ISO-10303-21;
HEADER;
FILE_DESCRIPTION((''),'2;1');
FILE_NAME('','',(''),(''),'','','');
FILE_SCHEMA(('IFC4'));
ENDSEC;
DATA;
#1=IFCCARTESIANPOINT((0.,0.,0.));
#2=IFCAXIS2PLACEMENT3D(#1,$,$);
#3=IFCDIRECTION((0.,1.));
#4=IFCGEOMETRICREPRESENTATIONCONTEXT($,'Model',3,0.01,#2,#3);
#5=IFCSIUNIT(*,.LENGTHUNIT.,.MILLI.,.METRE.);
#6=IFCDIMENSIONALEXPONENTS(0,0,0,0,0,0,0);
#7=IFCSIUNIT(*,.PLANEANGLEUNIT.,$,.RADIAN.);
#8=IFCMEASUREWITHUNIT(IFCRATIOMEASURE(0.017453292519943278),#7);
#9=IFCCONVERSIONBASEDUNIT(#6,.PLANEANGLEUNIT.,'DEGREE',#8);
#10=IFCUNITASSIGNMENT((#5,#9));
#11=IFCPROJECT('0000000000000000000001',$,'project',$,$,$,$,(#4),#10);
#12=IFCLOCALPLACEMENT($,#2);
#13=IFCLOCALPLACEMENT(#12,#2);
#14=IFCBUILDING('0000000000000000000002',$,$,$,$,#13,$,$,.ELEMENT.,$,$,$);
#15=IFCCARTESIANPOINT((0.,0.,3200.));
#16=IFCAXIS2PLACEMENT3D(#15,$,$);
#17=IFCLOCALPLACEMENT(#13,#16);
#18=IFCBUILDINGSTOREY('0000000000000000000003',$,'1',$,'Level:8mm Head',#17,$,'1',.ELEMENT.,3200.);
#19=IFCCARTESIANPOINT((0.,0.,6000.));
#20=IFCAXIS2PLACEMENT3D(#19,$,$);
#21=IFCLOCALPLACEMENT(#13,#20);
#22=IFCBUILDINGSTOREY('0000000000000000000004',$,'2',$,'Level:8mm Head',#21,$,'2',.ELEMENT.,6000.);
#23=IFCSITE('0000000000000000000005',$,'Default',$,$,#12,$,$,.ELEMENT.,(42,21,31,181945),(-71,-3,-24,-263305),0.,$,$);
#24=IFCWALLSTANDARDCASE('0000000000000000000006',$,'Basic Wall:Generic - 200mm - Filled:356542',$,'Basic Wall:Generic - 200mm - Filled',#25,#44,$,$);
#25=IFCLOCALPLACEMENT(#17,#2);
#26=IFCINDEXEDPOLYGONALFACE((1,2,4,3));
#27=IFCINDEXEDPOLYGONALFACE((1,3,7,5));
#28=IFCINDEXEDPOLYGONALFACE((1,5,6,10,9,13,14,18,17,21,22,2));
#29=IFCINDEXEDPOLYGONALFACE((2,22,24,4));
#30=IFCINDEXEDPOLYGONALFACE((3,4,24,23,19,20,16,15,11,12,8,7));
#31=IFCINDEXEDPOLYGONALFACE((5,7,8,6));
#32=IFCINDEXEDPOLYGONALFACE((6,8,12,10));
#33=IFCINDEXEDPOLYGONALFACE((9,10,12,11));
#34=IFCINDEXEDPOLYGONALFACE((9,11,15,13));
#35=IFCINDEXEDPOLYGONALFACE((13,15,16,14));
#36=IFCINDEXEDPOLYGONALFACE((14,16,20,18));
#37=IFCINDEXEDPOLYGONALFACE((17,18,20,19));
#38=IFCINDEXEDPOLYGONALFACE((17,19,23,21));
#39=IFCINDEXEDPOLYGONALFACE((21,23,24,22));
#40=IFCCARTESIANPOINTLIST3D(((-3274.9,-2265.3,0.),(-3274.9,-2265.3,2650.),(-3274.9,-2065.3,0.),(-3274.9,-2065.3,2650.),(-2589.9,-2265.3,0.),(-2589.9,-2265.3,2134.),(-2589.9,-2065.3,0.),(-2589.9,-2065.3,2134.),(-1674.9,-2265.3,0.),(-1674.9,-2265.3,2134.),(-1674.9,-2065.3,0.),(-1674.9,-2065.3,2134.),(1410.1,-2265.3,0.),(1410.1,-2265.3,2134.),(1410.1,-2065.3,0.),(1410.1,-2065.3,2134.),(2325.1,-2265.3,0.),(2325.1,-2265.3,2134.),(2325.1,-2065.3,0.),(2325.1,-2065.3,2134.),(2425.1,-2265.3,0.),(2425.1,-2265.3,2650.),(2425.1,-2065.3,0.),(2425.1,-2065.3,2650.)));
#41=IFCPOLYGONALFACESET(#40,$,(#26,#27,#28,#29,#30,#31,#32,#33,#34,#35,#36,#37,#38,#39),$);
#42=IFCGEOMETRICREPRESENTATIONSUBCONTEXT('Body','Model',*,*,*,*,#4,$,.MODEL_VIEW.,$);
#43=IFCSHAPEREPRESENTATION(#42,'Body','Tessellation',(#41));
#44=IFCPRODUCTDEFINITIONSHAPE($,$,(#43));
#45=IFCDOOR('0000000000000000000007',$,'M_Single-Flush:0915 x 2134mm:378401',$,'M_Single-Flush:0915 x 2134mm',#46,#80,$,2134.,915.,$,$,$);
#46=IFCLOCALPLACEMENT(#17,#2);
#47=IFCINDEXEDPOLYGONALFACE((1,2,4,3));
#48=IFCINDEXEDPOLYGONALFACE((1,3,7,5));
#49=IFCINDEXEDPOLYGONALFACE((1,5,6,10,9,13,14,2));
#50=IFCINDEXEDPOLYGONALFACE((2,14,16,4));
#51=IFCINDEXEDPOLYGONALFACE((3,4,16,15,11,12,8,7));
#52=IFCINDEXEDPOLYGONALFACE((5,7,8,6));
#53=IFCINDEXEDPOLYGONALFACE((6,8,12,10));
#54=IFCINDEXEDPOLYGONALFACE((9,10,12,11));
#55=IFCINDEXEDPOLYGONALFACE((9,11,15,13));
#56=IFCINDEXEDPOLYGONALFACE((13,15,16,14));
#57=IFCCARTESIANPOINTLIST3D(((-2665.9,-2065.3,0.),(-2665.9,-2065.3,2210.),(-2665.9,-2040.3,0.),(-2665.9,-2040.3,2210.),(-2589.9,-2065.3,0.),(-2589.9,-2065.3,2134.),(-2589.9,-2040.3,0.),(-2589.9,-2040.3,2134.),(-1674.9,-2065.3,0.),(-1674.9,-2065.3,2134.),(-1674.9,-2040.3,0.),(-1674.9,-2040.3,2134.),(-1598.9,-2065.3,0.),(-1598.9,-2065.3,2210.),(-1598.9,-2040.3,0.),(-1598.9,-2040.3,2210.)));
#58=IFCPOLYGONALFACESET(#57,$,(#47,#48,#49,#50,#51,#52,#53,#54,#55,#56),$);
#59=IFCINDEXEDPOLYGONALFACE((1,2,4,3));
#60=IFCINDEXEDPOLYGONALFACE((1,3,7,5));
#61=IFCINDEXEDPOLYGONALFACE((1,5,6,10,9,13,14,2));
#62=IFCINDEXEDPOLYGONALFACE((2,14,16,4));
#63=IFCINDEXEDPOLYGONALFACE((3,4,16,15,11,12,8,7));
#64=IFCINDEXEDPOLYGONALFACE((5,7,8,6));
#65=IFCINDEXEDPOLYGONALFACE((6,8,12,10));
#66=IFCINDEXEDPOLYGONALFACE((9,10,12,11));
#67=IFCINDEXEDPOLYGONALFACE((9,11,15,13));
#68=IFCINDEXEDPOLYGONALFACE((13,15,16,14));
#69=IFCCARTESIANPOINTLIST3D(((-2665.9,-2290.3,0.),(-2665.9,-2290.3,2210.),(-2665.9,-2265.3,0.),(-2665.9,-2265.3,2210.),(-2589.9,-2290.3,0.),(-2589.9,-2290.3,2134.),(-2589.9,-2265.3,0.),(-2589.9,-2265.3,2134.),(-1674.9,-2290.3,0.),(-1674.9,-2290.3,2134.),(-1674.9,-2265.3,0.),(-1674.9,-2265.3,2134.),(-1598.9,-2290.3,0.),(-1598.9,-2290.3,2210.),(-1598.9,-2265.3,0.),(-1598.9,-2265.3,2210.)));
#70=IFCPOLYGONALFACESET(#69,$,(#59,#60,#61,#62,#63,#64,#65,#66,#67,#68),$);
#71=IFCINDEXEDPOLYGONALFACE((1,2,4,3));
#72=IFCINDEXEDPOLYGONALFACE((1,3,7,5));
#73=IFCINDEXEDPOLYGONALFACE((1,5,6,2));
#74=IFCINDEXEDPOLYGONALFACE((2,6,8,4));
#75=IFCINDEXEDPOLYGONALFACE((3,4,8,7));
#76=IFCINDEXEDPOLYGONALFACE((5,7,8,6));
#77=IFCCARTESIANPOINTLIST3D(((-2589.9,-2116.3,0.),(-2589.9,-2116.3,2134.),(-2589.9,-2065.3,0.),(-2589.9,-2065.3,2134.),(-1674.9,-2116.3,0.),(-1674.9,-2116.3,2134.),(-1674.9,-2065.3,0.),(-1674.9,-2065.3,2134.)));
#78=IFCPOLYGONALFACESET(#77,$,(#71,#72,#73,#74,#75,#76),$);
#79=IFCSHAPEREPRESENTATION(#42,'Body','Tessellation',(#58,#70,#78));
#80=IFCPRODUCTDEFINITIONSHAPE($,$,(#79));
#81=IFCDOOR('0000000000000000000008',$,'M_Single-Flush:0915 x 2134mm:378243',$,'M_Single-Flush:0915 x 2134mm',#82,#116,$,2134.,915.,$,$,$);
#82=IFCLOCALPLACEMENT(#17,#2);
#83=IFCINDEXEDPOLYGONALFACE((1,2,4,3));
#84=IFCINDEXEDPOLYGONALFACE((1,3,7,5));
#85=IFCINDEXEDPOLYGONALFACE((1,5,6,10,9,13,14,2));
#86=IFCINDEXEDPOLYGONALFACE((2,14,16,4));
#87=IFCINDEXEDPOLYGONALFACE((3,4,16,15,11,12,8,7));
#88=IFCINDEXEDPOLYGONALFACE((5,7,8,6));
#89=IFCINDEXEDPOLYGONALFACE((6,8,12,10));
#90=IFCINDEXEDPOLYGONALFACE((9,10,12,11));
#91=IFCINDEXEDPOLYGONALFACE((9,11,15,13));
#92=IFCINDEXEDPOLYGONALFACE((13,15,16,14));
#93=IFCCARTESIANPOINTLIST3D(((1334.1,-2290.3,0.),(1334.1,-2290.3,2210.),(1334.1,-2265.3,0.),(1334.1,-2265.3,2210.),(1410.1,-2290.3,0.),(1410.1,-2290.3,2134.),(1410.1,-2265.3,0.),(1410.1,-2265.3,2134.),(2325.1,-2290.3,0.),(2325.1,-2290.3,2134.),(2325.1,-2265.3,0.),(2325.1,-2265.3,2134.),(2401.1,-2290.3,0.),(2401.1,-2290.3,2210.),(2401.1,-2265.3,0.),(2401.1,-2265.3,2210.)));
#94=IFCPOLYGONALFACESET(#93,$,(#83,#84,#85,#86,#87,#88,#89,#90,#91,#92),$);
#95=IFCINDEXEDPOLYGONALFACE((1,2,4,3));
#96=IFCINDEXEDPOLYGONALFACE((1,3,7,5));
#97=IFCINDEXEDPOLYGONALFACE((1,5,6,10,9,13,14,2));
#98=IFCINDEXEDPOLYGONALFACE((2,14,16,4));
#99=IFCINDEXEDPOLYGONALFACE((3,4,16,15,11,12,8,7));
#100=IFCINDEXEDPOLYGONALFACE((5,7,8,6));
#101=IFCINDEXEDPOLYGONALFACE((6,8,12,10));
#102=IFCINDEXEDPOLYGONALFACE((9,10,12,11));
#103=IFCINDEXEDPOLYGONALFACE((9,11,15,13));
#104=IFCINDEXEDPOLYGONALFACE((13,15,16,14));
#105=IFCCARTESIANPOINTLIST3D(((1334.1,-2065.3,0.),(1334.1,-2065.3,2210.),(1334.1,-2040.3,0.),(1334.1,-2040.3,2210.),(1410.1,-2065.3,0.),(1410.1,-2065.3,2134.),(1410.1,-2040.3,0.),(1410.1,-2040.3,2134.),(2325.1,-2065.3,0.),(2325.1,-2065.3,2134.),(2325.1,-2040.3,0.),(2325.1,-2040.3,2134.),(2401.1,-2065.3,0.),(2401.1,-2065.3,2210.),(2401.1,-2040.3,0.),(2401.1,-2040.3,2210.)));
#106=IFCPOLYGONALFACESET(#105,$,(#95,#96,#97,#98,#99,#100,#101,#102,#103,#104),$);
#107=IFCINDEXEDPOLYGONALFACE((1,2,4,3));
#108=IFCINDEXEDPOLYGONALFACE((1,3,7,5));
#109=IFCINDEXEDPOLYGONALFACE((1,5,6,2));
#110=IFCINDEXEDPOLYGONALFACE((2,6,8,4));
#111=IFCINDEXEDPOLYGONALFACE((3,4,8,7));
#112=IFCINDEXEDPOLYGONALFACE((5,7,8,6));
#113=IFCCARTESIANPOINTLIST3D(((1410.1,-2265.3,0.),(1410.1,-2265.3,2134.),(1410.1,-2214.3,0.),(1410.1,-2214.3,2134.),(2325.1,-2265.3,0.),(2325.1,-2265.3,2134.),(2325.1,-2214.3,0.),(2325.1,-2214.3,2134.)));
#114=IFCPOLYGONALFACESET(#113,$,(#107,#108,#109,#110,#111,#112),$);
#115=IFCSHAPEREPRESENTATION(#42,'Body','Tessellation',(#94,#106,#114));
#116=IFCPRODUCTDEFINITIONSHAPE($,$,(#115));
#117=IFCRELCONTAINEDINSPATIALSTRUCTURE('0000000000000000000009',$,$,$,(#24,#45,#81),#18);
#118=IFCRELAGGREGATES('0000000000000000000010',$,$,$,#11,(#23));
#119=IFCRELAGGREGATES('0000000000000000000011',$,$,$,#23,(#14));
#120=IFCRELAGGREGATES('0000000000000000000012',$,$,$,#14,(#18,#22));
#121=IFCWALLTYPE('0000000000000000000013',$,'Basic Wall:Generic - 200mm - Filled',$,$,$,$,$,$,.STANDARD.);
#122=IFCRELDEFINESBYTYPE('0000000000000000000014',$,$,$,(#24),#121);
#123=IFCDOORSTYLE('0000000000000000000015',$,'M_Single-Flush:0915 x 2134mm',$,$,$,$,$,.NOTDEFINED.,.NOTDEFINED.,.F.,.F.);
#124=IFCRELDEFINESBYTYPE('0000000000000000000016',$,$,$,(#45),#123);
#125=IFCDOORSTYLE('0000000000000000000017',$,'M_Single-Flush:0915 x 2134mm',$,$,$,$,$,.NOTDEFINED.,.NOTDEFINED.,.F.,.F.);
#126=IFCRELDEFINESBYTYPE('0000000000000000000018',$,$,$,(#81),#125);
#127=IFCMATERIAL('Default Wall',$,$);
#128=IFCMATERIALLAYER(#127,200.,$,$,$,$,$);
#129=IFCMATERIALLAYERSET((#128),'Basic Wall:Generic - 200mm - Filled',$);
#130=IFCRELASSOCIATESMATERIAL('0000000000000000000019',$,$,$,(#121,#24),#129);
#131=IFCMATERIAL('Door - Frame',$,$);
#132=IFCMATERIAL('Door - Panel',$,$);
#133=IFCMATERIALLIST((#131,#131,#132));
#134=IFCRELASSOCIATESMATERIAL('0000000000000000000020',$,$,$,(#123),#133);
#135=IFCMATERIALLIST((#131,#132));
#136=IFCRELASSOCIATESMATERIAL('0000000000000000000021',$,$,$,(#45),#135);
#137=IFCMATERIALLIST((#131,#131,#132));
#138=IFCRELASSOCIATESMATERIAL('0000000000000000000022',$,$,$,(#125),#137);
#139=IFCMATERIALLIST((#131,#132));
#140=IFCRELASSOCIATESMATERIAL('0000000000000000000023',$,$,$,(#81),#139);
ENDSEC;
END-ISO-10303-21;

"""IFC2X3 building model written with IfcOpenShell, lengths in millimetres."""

from ifc_helpers import new_model, entity, si_unit, converted_unit, direction, frame, frame_2d, origin, place, context, subcontext, project, spatial, polyline, rectangle, outline, extrude, clip, bounded_halfspace, source, transform, mapped, material, material_list, layer, layer_set, layer_usage, type_object, type_shapes, element, fill, save


model = new_model("IFC2X3")

# Units and contexts
model_context = context("Model", 3, precision=0.01, world=origin(), true_north=direction((0.0, 1.0)))
body_context = subcontext(model_context, "Body", "Model", "MODEL_VIEW")
ifc_project = project(units=[si_unit("LENGTHUNIT", "METRE", prefix="MILLI"), converted_unit("PLANEANGLEUNIT", "DEGREE", entity("IfcRatioMeasure", 0.017453292519943278), si_unit("PLANEANGLEUNIT", "RADIAN"), dimensions=[0, 0, 0, 0, 0, 0, 0])], contexts=[model_context])

# Site, building, storey
site_placement = place(None, origin())
site = spatial("IfcSite", under=ifc_project, at=site_placement, Name="Default", CompositionType="ELEMENT", RefLatitude=(42, 21, 31, 181945), RefLongitude=(-71, -3, -24, -263305), RefElevation=0.0)
building_placement = place(site_placement, origin())
building = spatial("IfcBuilding", under=site, at=building_placement, CompositionType="ELEMENT")
storey_1_placement = place(building_placement, frame((0.0, 0.0, 3200.0)))
storey_1 = spatial("IfcBuildingStorey", under=building, at=storey_1_placement, Name="1", ObjectType="Level:8mm Head", LongName="1", CompositionType="ELEMENT", Elevation=3200.0)

# Shared definitions
ifc_material_1 = material(Name="Default Wall")

# Shared definitions
storey_2_placement = place(building_placement, frame((0.0, 0.0, 6000.0)))
storey_2 = spatial("IfcBuildingStorey", under=building, at=storey_2_placement, Name="2", ObjectType="Level:8mm Head", LongName="2", CompositionType="ELEMENT", Elevation=6000.0)

# Shared definitions
ifc_layer_1 = layer(ifc_material_1, 200.0)
ifc_layer_set_1 = layer_set([ifc_layer_1], Name="Basic Wall:Generic - 200mm - Filled")
wall_type_1 = type_object("IfcWallType", Name="Basic Wall:Generic - 200mm - Filled", PredefinedType="STANDARD", material=ifc_layer_set_1)

# Wall, openings, doors
ifc_layer_usage_1 = layer_usage(ifc_layer_set_1, "AXIS2", "NEGATIVE", 100.0)
wall_1_placement = place(storey_1_placement, frame((2425.1, -2165.3, 0.0), z_axis=(0.0, 0.0, 1.0), x_axis=(-1.0, 0.0, 0.0)))
wall_1 = element("IfcWallStandardCase", 1, at=wall_1_placement, inside=storey_1, type_object=wall_type_1, material=ifc_layer_usage_1, Name="Basic Wall:Generic - 200mm - Filled:356542", ObjectType="Basic Wall:Generic - 200mm - Filled", context=body_context, shape_type="Clipping", body=[
    clip(extrude(rectangle(XDim=5700.0, YDim=200.0, at=frame_2d((2850.0, 0.0), x_axis=(1.0, 0.0))), origin(), (0.0, 0.0, 1.0), 2650.0), bounded_halfspace(frame((0.0, -100.0, 2650.0), z_axis=(0.0, 0.0, -1.0), x_axis=(0.0, 1.0, 0.0)), True, frame((0.0, -100.0, 2650.0)), polyline([(0.0, 0.0), (1737360.0, 0.0), (1737360.0, 60960.0), (1036320.0, 60960.0), (975360.0, 60960.0), (365760.0, 60960.0), (335280.0, 60960.0), (0.0, 60960.0), (0.0, 0.0)]))),
])
opening_1_placement = place(wall_1_placement, frame((100.0, -100.0, 0.0)))
opening_1 = element("IfcOpeningElement", 2, at=opening_1_placement, cuts=wall_1, ObjectType="Opening", context=body_context, shape_type="SweptSolid", body=[
    extrude(rectangle(XDim=915.0, YDim=2134.0, at=frame_2d((1067.0, 457.5), x_axis=(0.0, 1.0))), frame((0.0, 0.0, 0.0), z_axis=(0.0, 1.0, 0.0), x_axis=(0.0, 0.0, 1.0)), (0.0, 0.0, 1.0), 200.0),
])
opening_2_placement = place(wall_1_placement, frame((5015.0, 100.0, 0.0)))
opening_2 = element("IfcOpeningElement", 3, at=opening_2_placement, cuts=wall_1, ObjectType="Opening", context=body_context, shape_type="SweptSolid", body=[
    extrude(rectangle(XDim=915.0, YDim=2134.0, at=frame_2d((1067.0, 457.5), x_axis=(0.0, -1.0))), frame((0.0, 0.0, 0.0), z_axis=(0.0, -1.0, 0.0), x_axis=(0.0, 0.0, 1.0)), (0.0, 0.0, 1.0), 200.0),
])
ifc_material_2 = material(Name="Door - Frame")
ifc_material_3 = material(Name="Door - Panel")
ifc_material_list_1 = material_list([ifc_material_2, ifc_material_3])
ifc_material_list_2 = material_list([ifc_material_2, ifc_material_2, ifc_material_3])
door_style_1 = type_object("IfcDoorStyle", Name="M_Single-Flush:0915 x 2134mm", ConstructionType="NOTDEFINED", OperationType="NOTDEFINED", ParameterTakesPrecedence=False, Sizeable=False, material=ifc_material_list_2)
shared_shape_1 = source(origin(), body_context, "Body", "SweptSolid", [
    extrude(outline(polyline([(-533.5, -1124.0), (533.5, -1124.0), (533.5, 1086.0), (457.5, 1086.0), (457.5, -1048.0), (-457.5, -1048.0), (-457.5, 1086.0), (-533.5, 1086.0), (-533.5, -1124.0)])), frame((457.5, 225.0, 1086.0), z_axis=(0.0, -1.0, 0.0), x_axis=(-1.0, 0.0, 0.0)), (0.0, 0.0, 1.0), 25.0),
    extrude(outline(polyline([(-1124.0, -533.5), (1086.0, -533.5), (1086.0, -457.5), (-1048.0, -457.5), (-1048.0, 457.5), (1086.0, 457.5), (1086.0, 533.5), (-1124.0, 533.5), (-1124.0, -533.5)])), frame((457.5, 0.0, 1086.0), z_axis=(0.0, -1.0, 0.0), x_axis=(0.0, 0.0, -1.0)), (0.0, 0.0, 1.0), 25.0),
    extrude(rectangle(XDim=915.0, YDim=51.0, at=frame_2d((0.0, 0.0), x_axis=(1.0, 0.0))), frame((457.5, 174.5, 0.0)), (0.0, 0.0, 1.0), 2134.0),
])
type_shapes(door_style_1, [shared_shape_1])
door_1_placement = place(opening_2_placement, frame((0.0, 0.0, 0.0), z_axis=(0.0, 0.0, 1.0), x_axis=(-1.0, 0.0, 0.0)))
door_1 = element("IfcDoor", 4, at=door_1_placement, inside=storey_1, type_object=door_style_1, material=ifc_material_list_1, Name="M_Single-Flush:0915 x 2134mm:378401", ObjectType="M_Single-Flush:0915 x 2134mm", OverallHeight=2134.0, OverallWidth=915.0, context=body_context, shape_type="MappedRepresentation", body=[
    mapped(shared_shape_1, transform((0.0, 0.0, 0.0), scale=1.0)),
])
fill(opening_2, door_1)
ifc_material_list_3 = material_list([ifc_material_2, ifc_material_3])
ifc_material_list_4 = material_list([ifc_material_2, ifc_material_2, ifc_material_3])
door_style_2 = type_object("IfcDoorStyle", Name="M_Single-Flush:0915 x 2134mm", ConstructionType="NOTDEFINED", OperationType="NOTDEFINED", ParameterTakesPrecedence=False, Sizeable=False, material=ifc_material_list_4)
shared_shape_2 = source(origin(), body_context, "Body", "SweptSolid", [
    extrude(outline(polyline([(-533.5, -1124.0), (533.5, -1124.0), (533.5, 1086.0), (457.5, 1086.0), (457.5, -1048.0), (-457.5, -1048.0), (-457.5, 1086.0), (-533.5, 1086.0), (-533.5, -1124.0)])), frame((457.5, 200.0, 1086.0), z_axis=(0.0, 1.0, 0.0), x_axis=(1.0, 0.0, 0.0)), (0.0, 0.0, 1.0), 25.0),
    extrude(outline(polyline([(-1124.0, -533.5), (1086.0, -533.5), (1086.0, -457.5), (-1048.0, -457.5), (-1048.0, 457.5), (1086.0, 457.5), (1086.0, 533.5), (-1124.0, 533.5), (-1124.0, -533.5)])), frame((457.5, -25.0, 1086.0), z_axis=(0.0, 1.0, 0.0), x_axis=(0.0, 0.0, -1.0)), (0.0, 0.0, 1.0), 25.0),
    extrude(rectangle(XDim=51.0, YDim=915.0, at=frame_2d((0.0, 0.0), x_axis=(1.0, 0.0))), frame((457.5, 174.5, 0.0), z_axis=(0.0, 0.0, 1.0), x_axis=(0.0, 1.0, 0.0)), (0.0, 0.0, 1.0), 2134.0),
])
type_shapes(door_style_2, [shared_shape_2])
door_2_placement = place(opening_1_placement, origin())
door_2 = element("IfcDoor", 5, at=door_2_placement, inside=storey_1, type_object=door_style_2, material=ifc_material_list_3, Name="M_Single-Flush:0915 x 2134mm:378243", ObjectType="M_Single-Flush:0915 x 2134mm", OverallHeight=2134.0, OverallWidth=915.0, context=body_context, shape_type="MappedRepresentation", body=[
    mapped(shared_shape_2, transform((0.0, 0.0, 0.0), scale=1.0)),
])
fill(opening_1, door_2)

save(model, "model.ifc")
